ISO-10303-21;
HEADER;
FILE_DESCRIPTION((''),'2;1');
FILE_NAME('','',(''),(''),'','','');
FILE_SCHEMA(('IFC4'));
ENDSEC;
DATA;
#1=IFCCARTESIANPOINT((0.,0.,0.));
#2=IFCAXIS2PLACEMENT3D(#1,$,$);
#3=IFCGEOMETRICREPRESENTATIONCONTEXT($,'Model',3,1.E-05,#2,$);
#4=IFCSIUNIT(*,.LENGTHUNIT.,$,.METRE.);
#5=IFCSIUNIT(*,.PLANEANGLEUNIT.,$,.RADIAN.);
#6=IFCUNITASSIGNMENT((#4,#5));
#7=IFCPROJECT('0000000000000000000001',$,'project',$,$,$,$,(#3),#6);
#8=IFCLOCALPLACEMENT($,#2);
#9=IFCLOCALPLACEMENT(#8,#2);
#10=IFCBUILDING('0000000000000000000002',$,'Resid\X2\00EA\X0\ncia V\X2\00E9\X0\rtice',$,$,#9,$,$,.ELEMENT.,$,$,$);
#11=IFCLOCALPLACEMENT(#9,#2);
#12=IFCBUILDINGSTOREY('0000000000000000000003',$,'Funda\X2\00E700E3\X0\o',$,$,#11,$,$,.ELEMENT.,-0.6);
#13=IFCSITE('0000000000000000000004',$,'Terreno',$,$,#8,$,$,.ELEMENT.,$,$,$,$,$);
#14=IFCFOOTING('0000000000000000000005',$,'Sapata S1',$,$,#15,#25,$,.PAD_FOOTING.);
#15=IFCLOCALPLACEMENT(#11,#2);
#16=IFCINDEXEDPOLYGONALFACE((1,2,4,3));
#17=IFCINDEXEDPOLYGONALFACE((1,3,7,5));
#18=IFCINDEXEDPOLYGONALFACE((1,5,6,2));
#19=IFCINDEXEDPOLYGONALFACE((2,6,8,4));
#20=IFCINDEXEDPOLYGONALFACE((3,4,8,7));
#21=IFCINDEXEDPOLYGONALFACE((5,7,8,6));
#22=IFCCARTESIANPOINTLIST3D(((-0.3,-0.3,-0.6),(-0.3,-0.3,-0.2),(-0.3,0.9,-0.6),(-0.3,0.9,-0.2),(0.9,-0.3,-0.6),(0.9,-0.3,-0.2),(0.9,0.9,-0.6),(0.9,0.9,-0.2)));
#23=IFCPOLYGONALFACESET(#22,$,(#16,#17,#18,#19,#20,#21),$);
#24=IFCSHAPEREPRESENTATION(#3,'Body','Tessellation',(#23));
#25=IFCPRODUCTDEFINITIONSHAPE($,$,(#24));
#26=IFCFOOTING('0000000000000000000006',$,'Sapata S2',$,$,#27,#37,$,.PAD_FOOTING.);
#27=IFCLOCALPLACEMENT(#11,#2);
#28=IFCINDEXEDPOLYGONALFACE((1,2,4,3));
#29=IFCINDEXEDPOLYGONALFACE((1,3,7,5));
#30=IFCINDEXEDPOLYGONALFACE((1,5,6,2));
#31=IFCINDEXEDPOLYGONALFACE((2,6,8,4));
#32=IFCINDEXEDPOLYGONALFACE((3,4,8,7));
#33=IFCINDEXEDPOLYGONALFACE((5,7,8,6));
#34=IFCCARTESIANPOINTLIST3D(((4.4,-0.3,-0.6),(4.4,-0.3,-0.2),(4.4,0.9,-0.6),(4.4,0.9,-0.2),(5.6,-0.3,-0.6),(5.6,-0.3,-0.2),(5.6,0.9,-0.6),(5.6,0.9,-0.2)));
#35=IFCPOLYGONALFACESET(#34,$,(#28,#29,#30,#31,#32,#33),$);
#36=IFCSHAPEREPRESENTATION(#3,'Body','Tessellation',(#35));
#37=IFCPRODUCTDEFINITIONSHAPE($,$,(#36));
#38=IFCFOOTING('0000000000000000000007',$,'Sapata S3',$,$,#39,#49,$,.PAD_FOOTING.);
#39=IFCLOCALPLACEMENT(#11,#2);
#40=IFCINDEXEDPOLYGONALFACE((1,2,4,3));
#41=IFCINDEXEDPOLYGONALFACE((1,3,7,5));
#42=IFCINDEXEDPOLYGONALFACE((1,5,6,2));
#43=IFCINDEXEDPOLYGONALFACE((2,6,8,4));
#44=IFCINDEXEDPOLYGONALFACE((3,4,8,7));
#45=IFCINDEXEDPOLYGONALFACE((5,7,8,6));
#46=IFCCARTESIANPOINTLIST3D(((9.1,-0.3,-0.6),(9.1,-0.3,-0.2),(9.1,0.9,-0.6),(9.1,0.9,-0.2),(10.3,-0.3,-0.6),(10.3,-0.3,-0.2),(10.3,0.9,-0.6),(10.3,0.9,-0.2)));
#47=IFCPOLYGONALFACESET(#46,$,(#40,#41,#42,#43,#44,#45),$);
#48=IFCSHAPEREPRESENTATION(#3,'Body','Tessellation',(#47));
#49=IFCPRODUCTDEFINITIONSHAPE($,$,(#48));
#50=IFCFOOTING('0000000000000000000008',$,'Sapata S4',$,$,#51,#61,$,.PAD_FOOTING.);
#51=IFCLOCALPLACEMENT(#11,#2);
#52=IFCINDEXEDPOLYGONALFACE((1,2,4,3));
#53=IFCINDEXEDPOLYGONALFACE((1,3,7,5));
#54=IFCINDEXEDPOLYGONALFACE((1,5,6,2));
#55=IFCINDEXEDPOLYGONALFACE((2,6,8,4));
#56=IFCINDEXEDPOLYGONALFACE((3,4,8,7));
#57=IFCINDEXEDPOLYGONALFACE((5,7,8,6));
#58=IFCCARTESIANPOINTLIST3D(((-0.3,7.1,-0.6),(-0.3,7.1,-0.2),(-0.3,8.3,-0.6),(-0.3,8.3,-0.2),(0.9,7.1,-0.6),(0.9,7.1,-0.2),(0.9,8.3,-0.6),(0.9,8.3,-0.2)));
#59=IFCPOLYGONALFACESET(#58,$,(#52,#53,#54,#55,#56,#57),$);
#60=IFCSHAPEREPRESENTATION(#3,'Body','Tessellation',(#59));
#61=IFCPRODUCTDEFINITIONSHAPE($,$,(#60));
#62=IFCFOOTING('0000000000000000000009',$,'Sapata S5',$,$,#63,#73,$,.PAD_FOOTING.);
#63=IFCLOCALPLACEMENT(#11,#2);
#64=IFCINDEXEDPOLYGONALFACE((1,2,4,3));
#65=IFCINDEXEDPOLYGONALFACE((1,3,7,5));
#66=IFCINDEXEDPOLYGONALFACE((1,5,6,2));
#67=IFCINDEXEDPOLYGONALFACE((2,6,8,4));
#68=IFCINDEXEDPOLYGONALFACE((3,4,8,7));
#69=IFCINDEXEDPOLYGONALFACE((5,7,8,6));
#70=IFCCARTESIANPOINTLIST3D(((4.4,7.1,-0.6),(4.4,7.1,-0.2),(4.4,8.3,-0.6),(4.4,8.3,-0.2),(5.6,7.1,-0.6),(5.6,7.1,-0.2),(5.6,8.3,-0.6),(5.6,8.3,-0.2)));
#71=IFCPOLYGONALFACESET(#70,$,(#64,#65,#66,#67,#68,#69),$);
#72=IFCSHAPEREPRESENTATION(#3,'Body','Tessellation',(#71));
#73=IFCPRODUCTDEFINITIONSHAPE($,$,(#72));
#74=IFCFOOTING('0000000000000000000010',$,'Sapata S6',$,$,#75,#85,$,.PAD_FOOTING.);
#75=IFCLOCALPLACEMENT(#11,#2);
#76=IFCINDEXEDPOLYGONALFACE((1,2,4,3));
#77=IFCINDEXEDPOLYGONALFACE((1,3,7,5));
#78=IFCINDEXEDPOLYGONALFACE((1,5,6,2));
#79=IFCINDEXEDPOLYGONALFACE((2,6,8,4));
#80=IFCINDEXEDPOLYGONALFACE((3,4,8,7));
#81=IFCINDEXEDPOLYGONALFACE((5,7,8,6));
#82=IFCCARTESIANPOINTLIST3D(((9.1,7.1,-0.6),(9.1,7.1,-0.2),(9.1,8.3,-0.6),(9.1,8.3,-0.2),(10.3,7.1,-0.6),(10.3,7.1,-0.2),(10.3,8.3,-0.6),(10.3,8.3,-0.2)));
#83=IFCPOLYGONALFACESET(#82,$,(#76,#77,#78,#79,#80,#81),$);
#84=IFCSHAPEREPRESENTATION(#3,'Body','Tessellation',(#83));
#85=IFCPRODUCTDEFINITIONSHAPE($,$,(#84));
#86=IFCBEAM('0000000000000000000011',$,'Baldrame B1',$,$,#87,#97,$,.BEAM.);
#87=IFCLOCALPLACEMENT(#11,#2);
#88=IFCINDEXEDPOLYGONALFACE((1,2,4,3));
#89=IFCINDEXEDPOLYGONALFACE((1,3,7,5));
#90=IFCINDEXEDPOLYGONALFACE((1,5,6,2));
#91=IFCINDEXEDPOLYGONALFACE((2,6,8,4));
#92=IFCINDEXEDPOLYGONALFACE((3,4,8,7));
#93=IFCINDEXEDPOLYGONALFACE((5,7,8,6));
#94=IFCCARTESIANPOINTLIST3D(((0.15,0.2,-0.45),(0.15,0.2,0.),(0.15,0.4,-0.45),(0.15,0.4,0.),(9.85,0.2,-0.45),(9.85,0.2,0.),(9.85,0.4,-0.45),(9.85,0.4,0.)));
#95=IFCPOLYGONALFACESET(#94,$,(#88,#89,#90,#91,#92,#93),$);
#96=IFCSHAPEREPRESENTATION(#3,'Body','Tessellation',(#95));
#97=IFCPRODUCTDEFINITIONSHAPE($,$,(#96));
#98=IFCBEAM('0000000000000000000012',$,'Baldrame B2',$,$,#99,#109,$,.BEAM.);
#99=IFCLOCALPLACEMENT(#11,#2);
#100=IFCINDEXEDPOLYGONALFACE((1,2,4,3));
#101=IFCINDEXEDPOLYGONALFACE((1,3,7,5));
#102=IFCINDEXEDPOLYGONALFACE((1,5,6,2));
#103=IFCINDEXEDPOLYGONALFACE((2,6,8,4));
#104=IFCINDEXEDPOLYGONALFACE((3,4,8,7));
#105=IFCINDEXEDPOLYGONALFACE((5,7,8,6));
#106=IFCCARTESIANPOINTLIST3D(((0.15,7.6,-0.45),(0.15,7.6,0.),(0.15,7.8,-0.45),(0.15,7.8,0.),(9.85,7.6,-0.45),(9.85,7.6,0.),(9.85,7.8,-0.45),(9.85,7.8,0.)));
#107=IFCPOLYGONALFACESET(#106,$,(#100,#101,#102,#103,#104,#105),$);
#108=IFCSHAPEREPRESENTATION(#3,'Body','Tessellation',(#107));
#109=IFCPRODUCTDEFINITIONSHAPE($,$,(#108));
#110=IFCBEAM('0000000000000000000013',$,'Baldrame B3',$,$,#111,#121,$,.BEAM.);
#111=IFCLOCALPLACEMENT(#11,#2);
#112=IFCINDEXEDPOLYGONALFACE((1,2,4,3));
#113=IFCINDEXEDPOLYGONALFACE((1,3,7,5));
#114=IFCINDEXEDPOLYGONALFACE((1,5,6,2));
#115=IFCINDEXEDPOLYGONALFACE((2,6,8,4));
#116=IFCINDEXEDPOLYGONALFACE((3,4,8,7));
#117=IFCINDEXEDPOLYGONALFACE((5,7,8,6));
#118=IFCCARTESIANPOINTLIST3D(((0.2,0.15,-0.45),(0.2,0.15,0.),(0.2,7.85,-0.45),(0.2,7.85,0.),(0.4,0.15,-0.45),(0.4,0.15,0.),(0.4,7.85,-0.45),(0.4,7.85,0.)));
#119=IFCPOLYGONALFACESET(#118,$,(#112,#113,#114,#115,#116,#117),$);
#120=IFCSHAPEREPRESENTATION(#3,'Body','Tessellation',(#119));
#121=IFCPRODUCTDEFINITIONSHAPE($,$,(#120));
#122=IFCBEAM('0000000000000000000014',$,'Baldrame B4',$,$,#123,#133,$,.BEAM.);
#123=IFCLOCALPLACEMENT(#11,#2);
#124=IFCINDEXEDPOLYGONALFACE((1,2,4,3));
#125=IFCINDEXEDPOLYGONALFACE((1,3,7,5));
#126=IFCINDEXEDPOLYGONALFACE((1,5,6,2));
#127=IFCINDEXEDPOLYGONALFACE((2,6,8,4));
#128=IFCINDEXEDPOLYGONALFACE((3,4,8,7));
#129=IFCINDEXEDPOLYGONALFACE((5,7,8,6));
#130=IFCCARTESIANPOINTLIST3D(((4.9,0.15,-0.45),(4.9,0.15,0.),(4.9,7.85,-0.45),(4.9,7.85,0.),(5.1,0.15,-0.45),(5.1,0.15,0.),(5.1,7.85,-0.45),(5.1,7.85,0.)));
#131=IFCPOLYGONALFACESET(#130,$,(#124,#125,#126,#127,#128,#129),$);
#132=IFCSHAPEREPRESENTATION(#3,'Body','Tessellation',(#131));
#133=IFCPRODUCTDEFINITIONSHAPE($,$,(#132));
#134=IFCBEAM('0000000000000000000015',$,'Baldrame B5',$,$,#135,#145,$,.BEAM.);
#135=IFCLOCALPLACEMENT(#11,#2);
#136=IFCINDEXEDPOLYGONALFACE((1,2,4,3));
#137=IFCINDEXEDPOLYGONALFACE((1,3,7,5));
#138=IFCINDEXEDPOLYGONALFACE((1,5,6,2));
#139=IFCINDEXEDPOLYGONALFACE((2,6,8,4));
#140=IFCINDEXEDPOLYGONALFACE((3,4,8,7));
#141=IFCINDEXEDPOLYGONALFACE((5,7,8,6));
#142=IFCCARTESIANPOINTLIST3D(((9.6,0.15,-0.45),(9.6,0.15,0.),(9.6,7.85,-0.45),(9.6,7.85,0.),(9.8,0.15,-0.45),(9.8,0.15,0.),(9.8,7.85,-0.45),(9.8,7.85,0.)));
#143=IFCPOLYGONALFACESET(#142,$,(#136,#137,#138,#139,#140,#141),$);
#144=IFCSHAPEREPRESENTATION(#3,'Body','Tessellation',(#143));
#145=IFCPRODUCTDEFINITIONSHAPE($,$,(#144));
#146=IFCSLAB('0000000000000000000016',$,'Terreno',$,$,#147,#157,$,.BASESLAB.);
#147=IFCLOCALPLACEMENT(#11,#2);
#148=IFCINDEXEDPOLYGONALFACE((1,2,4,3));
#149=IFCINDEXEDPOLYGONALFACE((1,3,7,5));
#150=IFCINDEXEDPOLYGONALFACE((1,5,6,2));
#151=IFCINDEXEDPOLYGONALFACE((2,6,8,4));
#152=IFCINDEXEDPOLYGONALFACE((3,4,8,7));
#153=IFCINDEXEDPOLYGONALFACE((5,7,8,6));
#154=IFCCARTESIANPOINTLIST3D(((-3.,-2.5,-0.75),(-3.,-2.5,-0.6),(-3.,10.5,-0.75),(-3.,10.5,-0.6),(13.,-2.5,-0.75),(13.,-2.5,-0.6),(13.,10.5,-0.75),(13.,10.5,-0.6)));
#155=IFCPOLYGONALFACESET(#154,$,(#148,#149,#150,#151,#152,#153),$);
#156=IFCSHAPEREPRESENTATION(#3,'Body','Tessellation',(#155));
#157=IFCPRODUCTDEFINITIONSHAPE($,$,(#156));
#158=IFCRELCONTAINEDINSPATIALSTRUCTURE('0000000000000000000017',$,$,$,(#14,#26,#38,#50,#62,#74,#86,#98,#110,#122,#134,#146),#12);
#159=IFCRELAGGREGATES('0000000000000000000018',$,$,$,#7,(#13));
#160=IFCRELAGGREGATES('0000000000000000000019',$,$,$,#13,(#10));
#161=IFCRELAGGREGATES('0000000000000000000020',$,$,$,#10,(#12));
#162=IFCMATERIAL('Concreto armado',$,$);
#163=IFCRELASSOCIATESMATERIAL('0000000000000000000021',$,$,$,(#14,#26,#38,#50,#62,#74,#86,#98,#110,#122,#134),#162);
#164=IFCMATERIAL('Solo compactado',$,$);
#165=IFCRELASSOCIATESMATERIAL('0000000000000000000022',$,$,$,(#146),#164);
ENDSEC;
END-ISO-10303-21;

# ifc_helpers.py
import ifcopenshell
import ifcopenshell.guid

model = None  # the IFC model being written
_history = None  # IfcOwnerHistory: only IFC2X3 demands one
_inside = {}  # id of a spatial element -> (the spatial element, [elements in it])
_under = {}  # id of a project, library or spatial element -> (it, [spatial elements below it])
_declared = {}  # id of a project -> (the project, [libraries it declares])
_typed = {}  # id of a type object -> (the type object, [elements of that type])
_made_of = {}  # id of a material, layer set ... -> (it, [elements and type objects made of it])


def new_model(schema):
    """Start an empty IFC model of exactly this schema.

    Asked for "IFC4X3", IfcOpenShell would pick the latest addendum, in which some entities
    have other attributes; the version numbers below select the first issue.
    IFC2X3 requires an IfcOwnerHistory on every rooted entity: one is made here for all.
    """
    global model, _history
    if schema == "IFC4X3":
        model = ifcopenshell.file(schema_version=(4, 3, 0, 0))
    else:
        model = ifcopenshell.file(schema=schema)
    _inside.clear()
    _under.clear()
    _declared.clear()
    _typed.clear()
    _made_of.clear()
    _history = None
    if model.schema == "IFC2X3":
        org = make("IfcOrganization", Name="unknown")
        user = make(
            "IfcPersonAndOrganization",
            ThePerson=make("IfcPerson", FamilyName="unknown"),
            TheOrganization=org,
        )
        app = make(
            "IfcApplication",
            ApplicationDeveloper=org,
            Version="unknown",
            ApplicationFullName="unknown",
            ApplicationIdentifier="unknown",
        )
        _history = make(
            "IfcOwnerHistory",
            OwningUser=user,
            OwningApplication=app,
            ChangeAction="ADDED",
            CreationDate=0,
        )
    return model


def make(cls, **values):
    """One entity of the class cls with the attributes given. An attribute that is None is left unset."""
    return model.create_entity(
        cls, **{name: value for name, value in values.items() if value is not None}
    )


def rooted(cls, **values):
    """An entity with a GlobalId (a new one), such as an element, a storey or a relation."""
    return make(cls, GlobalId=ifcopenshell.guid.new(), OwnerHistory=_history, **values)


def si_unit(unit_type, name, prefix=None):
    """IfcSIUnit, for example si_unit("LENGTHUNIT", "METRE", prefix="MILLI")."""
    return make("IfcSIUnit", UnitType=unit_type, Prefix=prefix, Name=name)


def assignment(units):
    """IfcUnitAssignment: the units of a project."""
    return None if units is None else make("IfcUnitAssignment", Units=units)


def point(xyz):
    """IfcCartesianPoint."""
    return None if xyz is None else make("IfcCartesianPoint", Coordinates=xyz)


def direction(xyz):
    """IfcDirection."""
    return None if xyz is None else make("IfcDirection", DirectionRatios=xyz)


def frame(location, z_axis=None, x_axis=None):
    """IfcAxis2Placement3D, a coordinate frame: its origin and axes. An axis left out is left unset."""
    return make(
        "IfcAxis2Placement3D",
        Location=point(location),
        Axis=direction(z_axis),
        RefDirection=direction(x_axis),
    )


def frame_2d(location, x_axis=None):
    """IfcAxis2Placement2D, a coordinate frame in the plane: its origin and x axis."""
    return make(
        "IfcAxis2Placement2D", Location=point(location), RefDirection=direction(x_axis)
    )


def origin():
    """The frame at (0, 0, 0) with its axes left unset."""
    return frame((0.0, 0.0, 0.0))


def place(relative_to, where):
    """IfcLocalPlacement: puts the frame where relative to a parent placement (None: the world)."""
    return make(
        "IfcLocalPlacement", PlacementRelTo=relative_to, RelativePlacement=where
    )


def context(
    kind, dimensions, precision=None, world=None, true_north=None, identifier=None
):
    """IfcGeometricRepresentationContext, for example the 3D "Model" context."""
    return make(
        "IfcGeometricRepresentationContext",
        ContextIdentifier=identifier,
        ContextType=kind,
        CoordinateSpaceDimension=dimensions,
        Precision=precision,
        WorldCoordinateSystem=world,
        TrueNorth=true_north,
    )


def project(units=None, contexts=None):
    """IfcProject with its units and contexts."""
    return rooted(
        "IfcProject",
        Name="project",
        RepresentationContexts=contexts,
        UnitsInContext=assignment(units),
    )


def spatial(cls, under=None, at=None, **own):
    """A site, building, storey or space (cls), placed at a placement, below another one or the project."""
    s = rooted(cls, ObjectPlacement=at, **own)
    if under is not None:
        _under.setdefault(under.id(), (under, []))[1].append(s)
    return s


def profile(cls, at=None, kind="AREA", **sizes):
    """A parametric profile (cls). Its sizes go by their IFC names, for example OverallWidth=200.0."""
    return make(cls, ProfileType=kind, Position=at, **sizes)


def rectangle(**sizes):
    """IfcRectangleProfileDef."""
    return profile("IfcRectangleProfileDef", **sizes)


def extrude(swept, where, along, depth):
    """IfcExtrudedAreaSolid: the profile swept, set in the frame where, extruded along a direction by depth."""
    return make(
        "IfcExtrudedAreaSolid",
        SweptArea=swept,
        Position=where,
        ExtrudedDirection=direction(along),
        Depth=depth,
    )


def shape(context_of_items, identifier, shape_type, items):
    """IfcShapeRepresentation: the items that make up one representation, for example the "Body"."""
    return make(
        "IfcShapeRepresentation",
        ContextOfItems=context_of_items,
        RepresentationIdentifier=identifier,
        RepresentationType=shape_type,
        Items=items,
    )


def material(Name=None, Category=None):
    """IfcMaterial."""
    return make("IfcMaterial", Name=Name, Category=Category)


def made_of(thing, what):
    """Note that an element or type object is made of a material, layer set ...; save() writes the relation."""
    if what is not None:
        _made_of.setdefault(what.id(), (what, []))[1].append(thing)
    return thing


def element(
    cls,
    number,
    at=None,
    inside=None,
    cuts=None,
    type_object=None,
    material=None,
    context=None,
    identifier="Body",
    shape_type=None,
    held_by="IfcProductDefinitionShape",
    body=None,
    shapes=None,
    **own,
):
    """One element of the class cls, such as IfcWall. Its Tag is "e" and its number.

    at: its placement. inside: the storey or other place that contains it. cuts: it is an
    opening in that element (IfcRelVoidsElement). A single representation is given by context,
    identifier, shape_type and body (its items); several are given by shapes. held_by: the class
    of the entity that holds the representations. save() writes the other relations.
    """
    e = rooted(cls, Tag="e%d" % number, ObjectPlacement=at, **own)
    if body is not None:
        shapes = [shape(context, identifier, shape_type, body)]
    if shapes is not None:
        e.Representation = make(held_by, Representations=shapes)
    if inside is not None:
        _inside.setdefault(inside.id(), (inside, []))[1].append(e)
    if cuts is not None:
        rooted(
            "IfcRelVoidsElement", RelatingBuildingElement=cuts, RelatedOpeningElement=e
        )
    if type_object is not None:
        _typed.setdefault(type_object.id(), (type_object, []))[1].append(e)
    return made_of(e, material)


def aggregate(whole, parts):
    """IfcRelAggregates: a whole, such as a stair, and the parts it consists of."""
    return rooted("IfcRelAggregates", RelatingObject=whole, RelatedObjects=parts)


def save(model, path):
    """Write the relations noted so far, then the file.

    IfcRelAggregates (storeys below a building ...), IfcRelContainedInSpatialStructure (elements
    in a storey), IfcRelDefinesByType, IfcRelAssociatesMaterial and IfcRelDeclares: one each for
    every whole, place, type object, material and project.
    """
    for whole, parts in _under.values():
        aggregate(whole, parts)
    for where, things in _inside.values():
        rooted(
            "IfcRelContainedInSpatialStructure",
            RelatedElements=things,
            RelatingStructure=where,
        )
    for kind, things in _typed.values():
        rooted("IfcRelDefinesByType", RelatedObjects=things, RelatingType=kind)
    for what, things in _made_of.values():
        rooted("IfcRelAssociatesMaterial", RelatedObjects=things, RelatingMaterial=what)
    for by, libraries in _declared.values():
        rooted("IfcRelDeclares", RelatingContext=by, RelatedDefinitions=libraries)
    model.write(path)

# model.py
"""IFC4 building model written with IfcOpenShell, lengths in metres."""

from ifc_helpers import new_model, si_unit, frame, frame_2d, origin, place, context, project, spatial, rectangle, extrude, material, element, save


model = new_model("IFC4")

# Units and contexts
model_context = context("Model", 3, precision=1e-05, world=origin())
ifc_project = project(units=[si_unit("LENGTHUNIT", "METRE"), si_unit("PLANEANGLEUNIT", "RADIAN")], contexts=[model_context])

# Site, building, storey
site_placement = place(None, origin())
site = spatial("IfcSite", under=ifc_project, at=site_placement, Name="Terreno", CompositionType="ELEMENT")
building_placement = place(site_placement, origin())
building = spatial("IfcBuilding", under=site, at=building_placement, Name="Residência Vértice", CompositionType="ELEMENT")
storey_placement = place(building_placement, origin())
storey = spatial("IfcBuildingStorey", under=building, at=storey_placement, Name="Fundação", CompositionType="ELEMENT", Elevation=-0.6)

# Footings
ifc_material_1 = material(Name="Concreto armado")
footing_1_placement = place(storey_placement, origin())
element("IfcFooting", 1, at=footing_1_placement, inside=storey, material=ifc_material_1, Name="Sapata S1", PredefinedType="PAD_FOOTING", context=model_context, shape_type="SweptSolid", body=[
    extrude(rectangle(XDim=1.2, YDim=1.2, at=frame_2d((0.3, 0.3))), frame((0.0, 0.0, -0.6)), (0.0, 0.0, 1.0), 0.4),
])
footing_2_placement = place(storey_placement, origin())
element("IfcFooting", 2, at=footing_2_placement, inside=storey, material=ifc_material_1, Name="Sapata S2", PredefinedType="PAD_FOOTING", context=model_context, shape_type="SweptSolid", body=[
    extrude(rectangle(XDim=1.2, YDim=1.2, at=frame_2d((5.0, 0.3))), frame((0.0, 0.0, -0.6)), (0.0, 0.0, 1.0), 0.4),
])
footing_3_placement = place(storey_placement, origin())
element("IfcFooting", 3, at=footing_3_placement, inside=storey, material=ifc_material_1, Name="Sapata S3", PredefinedType="PAD_FOOTING", context=model_context, shape_type="SweptSolid", body=[
    extrude(rectangle(XDim=1.2, YDim=1.2, at=frame_2d((9.7, 0.3))), frame((0.0, 0.0, -0.6)), (0.0, 0.0, 1.0), 0.4),
])
footing_4_placement = place(storey_placement, origin())
element("IfcFooting", 4, at=footing_4_placement, inside=storey, material=ifc_material_1, Name="Sapata S4", PredefinedType="PAD_FOOTING", context=model_context, shape_type="SweptSolid", body=[
    extrude(rectangle(XDim=1.2, YDim=1.2, at=frame_2d((0.3, 7.7))), frame((0.0, 0.0, -0.6)), (0.0, 0.0, 1.0), 0.4),
])
footing_5_placement = place(storey_placement, origin())
element("IfcFooting", 5, at=footing_5_placement, inside=storey, material=ifc_material_1, Name="Sapata S5", PredefinedType="PAD_FOOTING", context=model_context, shape_type="SweptSolid", body=[
    extrude(rectangle(XDim=1.2, YDim=1.2, at=frame_2d((5.0, 7.7))), frame((0.0, 0.0, -0.6)), (0.0, 0.0, 1.0), 0.4),
])
footing_6_placement = place(storey_placement, origin())
element("IfcFooting", 6, at=footing_6_placement, inside=storey, material=ifc_material_1, Name="Sapata S6", PredefinedType="PAD_FOOTING", context=model_context, shape_type="SweptSolid", body=[
    extrude(rectangle(XDim=1.2, YDim=1.2, at=frame_2d((9.7, 7.7))), frame((0.0, 0.0, -0.6)), (0.0, 0.0, 1.0), 0.4),
])

# Beams
beam_1_placement = place(storey_placement, origin())
element("IfcBeam", 7, at=beam_1_placement, inside=storey, material=ifc_material_1, Name="Baldrame B1", PredefinedType="BEAM", context=model_context, shape_type="SweptSolid", body=[
    extrude(rectangle(XDim=9.7, YDim=0.2, at=frame_2d((5.0, 0.3))), frame((0.0, 0.0, -0.45)), (0.0, 0.0, 1.0), 0.45),
])
beam_2_placement = place(storey_placement, origin())
element("IfcBeam", 8, at=beam_2_placement, inside=storey, material=ifc_material_1, Name="Baldrame B2", PredefinedType="BEAM", context=model_context, shape_type="SweptSolid", body=[
    extrude(rectangle(XDim=9.7, YDim=0.2, at=frame_2d((5.0, 7.7))), frame((0.0, 0.0, -0.45)), (0.0, 0.0, 1.0), 0.45),
])
beam_3_placement = place(storey_placement, origin())
element("IfcBeam", 9, at=beam_3_placement, inside=storey, material=ifc_material_1, Name="Baldrame B3", PredefinedType="BEAM", context=model_context, shape_type="SweptSolid", body=[
    extrude(rectangle(XDim=0.2, YDim=7.7, at=frame_2d((0.3, 4.0))), frame((0.0, 0.0, -0.45)), (0.0, 0.0, 1.0), 0.45),
])
beam_4_placement = place(storey_placement, origin())
element("IfcBeam", 10, at=beam_4_placement, inside=storey, material=ifc_material_1, Name="Baldrame B4", PredefinedType="BEAM", context=model_context, shape_type="SweptSolid", body=[
    extrude(rectangle(XDim=0.2, YDim=7.7, at=frame_2d((5.0, 4.0))), frame((0.0, 0.0, -0.45)), (0.0, 0.0, 1.0), 0.45),
])
beam_5_placement = place(storey_placement, origin())
element("IfcBeam", 11, at=beam_5_placement, inside=storey, material=ifc_material_1, Name="Baldrame B5", PredefinedType="BEAM", context=model_context, shape_type="SweptSolid", body=[
    extrude(rectangle(XDim=0.2, YDim=7.7, at=frame_2d((9.7, 4.0))), frame((0.0, 0.0, -0.45)), (0.0, 0.0, 1.0), 0.45),
])

# Slab
ifc_material_2 = material(Name="Solo compactado")
slab_placement = place(storey_placement, origin())
element("IfcSlab", 12, at=slab_placement, inside=storey, material=ifc_material_2, Name="Terreno", PredefinedType="BASESLAB", context=model_context, shape_type="SweptSolid", body=[
    extrude(rectangle(XDim=16.0, YDim=13.0, at=frame_2d((5.0, 4.0))), frame((0.0, 0.0, -0.75)), (0.0, 0.0, 1.0), 0.15),
])

save(model, "model.ifc")
